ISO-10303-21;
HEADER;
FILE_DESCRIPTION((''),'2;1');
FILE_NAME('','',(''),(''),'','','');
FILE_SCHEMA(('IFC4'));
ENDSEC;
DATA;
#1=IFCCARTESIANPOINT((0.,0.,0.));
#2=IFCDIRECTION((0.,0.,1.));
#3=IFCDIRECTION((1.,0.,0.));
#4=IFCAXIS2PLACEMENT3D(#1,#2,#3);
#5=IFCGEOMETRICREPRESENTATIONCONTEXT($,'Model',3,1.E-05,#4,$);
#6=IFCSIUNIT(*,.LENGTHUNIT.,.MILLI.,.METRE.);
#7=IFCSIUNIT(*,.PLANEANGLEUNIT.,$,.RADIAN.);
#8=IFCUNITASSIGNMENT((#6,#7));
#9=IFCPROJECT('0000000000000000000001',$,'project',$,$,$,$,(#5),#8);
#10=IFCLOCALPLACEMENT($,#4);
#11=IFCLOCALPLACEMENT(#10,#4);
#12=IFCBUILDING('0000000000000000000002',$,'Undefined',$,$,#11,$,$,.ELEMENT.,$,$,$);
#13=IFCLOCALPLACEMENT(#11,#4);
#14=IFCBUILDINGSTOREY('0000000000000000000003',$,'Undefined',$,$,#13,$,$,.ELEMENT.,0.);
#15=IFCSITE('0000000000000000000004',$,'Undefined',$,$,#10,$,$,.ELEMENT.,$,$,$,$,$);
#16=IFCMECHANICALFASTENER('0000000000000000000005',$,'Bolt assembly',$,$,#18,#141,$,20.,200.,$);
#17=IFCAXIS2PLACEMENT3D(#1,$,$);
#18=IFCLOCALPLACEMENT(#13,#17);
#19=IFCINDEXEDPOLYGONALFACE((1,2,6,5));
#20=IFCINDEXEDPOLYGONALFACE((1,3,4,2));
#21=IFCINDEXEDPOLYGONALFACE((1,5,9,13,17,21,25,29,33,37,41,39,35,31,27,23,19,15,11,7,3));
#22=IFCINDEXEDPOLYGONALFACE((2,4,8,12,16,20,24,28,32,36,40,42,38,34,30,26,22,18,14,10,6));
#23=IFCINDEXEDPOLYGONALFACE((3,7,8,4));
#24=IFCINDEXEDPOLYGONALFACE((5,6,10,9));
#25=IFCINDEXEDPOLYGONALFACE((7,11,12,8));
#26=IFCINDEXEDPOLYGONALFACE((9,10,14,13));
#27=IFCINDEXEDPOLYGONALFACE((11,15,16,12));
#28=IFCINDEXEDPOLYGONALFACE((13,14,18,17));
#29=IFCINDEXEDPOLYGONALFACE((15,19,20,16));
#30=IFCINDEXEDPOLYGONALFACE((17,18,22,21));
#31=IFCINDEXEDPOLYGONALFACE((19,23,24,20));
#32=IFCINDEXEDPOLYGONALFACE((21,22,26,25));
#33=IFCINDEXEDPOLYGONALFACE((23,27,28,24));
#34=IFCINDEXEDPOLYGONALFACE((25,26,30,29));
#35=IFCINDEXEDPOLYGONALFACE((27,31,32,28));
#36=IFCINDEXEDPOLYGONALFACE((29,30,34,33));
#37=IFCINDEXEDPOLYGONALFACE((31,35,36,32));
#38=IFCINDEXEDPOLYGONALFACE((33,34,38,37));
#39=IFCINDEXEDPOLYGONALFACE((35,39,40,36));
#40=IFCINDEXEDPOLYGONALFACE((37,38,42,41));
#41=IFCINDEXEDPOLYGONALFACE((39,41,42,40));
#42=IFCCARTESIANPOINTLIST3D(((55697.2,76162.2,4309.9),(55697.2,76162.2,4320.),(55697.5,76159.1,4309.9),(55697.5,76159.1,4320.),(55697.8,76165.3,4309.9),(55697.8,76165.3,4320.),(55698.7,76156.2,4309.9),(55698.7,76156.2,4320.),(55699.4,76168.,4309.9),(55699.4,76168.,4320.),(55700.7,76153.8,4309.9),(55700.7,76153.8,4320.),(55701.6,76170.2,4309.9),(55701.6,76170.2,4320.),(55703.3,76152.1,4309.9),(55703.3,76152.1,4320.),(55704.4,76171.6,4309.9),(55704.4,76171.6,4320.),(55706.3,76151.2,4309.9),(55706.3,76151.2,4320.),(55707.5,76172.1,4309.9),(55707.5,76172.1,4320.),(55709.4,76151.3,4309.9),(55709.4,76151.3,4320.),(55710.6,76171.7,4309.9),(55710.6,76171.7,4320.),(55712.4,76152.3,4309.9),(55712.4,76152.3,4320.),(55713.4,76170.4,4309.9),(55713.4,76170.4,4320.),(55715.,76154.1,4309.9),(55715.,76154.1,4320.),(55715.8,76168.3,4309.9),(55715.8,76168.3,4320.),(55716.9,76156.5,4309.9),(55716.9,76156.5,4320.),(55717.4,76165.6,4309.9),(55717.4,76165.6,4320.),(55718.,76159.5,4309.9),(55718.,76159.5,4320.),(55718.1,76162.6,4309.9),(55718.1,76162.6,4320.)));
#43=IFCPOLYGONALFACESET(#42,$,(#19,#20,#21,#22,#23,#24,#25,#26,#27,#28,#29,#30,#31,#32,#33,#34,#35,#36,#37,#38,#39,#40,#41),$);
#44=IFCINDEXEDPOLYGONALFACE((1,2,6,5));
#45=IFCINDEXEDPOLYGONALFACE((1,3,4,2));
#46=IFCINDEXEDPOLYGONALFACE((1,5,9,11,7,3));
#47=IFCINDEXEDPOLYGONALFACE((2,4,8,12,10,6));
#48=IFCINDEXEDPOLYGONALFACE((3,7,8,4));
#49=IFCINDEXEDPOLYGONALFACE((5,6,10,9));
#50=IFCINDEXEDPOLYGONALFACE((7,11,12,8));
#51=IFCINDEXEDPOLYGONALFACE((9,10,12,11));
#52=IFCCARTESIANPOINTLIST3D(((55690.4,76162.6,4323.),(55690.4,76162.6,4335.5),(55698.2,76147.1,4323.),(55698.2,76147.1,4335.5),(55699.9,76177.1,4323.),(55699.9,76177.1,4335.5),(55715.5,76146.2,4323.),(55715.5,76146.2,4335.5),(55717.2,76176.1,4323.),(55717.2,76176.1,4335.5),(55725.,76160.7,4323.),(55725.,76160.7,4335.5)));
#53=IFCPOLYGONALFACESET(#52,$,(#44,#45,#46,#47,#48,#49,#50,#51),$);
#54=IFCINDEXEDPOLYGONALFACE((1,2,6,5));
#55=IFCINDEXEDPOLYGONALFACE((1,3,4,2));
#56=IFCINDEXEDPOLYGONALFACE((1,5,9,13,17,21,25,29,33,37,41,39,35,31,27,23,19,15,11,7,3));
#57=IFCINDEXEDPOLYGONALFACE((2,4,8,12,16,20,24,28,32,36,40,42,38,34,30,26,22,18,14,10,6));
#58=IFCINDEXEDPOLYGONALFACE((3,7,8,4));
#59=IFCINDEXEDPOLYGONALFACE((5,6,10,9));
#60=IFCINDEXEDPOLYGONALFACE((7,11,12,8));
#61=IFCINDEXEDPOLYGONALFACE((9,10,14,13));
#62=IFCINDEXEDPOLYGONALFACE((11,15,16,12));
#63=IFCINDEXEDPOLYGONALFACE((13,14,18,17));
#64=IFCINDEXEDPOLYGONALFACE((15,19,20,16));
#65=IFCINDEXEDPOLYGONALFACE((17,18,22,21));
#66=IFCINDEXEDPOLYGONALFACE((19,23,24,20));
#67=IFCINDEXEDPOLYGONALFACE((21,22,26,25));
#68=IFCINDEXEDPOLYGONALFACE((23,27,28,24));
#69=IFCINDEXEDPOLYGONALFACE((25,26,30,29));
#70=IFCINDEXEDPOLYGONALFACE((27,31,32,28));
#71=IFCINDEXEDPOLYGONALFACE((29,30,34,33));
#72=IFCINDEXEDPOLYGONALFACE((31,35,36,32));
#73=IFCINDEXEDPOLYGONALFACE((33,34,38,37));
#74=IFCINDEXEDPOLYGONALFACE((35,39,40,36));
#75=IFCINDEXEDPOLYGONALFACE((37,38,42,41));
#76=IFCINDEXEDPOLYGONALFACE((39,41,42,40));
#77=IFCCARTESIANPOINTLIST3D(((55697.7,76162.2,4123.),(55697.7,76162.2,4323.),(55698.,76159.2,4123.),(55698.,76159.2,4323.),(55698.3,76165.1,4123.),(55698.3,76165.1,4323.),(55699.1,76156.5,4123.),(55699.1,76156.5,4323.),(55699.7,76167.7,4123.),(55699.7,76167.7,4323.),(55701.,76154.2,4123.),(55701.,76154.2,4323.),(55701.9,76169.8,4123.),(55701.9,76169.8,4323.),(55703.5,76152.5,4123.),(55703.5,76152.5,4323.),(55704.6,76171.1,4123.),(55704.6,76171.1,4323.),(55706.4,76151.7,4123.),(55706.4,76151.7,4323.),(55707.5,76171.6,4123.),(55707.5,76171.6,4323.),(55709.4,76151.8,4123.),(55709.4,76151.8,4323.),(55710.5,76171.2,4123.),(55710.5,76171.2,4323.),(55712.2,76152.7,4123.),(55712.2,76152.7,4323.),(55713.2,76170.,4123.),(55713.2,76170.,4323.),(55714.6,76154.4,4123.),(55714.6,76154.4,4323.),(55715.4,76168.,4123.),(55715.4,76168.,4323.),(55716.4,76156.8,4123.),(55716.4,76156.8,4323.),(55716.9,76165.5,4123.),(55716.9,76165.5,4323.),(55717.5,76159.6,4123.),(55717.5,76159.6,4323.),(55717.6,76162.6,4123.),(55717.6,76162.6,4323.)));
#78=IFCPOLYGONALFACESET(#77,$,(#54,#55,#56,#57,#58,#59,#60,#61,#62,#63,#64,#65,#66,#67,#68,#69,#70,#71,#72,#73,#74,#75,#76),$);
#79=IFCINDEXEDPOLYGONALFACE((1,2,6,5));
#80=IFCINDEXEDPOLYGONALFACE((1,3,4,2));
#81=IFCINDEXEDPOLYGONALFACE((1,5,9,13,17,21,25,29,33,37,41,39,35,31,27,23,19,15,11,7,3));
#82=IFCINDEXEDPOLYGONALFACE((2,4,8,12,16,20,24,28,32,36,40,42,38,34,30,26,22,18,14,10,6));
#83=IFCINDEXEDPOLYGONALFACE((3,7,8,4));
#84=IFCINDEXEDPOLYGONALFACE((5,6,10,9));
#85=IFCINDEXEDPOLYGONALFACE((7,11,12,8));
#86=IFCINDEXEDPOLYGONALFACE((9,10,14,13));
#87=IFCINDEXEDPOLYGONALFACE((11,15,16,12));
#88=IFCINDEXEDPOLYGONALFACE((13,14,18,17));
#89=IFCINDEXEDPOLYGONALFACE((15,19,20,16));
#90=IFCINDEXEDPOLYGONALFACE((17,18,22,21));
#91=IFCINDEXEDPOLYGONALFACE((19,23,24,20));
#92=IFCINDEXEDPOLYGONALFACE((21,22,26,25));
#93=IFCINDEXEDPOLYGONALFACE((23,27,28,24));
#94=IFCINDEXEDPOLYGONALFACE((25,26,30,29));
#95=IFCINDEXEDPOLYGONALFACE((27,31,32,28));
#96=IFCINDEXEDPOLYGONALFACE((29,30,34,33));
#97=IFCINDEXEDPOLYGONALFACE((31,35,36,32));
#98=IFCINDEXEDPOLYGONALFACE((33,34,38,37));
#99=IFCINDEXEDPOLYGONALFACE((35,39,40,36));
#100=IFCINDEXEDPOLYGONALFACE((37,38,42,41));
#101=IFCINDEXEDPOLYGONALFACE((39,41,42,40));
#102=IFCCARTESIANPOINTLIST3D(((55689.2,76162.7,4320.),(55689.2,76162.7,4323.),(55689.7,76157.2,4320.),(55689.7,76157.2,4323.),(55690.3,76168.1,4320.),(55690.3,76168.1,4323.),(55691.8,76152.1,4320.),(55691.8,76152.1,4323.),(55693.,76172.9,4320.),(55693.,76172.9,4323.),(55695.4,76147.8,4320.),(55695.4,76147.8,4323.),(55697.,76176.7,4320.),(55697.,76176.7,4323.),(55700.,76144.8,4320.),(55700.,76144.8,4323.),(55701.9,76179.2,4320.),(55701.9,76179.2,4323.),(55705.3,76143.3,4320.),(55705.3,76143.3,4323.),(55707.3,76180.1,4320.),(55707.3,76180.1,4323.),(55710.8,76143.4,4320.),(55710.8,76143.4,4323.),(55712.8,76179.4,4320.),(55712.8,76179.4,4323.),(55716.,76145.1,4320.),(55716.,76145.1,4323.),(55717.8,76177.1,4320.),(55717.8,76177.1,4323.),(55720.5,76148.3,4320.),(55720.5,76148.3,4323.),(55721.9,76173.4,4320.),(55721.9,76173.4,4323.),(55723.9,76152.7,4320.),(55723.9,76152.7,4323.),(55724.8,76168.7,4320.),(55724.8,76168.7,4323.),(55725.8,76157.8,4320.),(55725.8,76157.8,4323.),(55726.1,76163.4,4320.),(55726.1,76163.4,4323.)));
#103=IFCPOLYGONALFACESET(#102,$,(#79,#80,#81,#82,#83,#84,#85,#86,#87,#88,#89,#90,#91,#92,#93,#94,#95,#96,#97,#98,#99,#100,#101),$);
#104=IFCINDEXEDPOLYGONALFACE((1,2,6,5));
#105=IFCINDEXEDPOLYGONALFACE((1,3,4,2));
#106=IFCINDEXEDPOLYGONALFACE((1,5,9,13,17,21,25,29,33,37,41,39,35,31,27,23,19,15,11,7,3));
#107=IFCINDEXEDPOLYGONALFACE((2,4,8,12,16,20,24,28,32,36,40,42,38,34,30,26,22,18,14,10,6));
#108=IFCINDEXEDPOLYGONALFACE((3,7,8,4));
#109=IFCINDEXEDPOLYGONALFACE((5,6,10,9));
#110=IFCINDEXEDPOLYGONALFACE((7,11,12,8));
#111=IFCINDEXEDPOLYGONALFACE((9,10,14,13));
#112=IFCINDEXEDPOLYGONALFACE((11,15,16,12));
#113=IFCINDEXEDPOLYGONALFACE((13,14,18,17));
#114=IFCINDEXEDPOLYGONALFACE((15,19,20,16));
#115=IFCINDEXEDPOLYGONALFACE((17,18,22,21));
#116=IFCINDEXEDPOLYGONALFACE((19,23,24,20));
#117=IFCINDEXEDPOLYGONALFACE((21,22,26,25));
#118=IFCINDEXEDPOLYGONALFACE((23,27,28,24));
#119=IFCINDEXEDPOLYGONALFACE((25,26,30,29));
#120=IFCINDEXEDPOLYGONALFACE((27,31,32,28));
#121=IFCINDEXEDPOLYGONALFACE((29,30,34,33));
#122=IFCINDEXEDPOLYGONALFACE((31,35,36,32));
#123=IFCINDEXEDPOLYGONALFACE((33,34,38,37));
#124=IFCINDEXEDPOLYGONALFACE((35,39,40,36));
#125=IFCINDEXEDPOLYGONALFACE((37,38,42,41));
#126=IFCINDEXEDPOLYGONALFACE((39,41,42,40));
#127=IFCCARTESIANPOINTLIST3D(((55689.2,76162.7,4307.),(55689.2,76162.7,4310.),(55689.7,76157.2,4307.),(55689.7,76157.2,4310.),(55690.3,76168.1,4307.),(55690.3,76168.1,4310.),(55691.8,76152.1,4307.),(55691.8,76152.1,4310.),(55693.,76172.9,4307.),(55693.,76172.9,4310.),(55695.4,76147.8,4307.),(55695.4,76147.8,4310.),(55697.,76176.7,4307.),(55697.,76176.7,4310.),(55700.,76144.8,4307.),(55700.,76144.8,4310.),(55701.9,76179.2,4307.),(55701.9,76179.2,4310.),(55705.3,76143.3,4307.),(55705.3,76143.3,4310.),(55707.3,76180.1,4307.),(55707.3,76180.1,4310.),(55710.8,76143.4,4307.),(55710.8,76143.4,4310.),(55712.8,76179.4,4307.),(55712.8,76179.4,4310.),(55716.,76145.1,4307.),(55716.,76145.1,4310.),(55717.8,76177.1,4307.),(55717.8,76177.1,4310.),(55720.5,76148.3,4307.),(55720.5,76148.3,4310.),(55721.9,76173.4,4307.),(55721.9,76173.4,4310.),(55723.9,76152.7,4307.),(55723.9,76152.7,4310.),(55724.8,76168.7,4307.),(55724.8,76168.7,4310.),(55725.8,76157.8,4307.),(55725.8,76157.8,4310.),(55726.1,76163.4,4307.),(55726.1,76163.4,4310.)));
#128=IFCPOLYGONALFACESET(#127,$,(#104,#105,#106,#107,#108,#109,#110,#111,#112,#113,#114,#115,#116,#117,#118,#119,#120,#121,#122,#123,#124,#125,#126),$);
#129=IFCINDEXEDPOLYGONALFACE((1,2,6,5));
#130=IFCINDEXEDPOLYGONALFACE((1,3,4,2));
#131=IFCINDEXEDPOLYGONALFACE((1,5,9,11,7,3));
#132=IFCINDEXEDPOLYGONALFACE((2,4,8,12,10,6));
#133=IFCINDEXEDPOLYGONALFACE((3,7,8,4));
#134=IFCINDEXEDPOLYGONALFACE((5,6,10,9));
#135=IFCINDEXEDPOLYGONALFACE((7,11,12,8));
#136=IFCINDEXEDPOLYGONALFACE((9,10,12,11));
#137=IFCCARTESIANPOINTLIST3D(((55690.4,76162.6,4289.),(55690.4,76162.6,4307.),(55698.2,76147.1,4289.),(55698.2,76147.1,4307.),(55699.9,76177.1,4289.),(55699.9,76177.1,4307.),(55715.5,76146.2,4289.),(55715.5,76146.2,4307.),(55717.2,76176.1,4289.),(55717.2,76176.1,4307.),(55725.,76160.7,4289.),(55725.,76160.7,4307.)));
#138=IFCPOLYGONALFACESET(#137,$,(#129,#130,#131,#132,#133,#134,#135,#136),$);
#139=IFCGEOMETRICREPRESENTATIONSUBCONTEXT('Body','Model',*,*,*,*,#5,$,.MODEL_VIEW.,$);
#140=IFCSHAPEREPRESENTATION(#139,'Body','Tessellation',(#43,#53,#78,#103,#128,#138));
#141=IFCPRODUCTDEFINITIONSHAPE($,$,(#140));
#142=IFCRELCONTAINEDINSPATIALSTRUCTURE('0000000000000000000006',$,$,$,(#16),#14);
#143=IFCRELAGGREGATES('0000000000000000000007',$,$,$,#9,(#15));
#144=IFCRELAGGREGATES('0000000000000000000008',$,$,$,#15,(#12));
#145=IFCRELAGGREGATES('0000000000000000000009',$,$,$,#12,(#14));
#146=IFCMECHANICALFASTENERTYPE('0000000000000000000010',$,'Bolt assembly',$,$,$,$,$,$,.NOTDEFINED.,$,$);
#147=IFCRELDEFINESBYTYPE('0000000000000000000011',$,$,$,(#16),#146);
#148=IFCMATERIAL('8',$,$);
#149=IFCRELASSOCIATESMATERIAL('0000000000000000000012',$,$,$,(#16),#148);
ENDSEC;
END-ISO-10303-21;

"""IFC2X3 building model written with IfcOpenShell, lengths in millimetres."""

from ifc_helpers import new_model, si_unit, frame, origin_with_axes, origin_2d_with_axis, place, context, subcontext, project, spatial, polyline, circle, outline, extrude, source, transform, mapped, material, type_object, element, save


model = new_model("IFC2X3")

# Units and contexts
model_context = context("Model", 3, precision=1e-05, world=origin_with_axes())
body_context = subcontext(model_context, "Body", "Model", "MODEL_VIEW")
ifc_project = project(units=[si_unit("LENGTHUNIT", "METRE", prefix="MILLI"), si_unit("PLANEANGLEUNIT", "RADIAN")], contexts=[model_context])

# Site, building, storey
site_placement = place(None, origin_with_axes())
site = spatial("IfcSite", under=ifc_project, at=site_placement, Name="Undefined", CompositionType="ELEMENT")
building_placement = place(site_placement, origin_with_axes())
building = spatial("IfcBuilding", under=site, at=building_placement, Name="Undefined", CompositionType="ELEMENT")
storey_placement = place(building_placement, origin_with_axes())
storey = spatial("IfcBuildingStorey", under=building, at=storey_placement, Name="Undefined", CompositionType="ELEMENT", Elevation=0.0)

# Mechanical fastener
ifc_material_1 = material(Name="8")
mechanical_fastener_type = type_object("IfcMechanicalFastenerType", Name="Bolt assembly")
shared_shape_1 = source(origin_with_axes(), body_context, "Body", "SweptSolid", [
    extrude(circle(Radius=10.5, at=origin_2d_with_axis()), frame((0.0, 0.0, 0.0), z_axis=(0.0, 1.0, 0.0), x_axis=(1.0, 0.0, 0.0)), (0.0, 0.0, 1.0), 10.1),
    extrude(outline(polyline([(17.3, 0.0), (8.7, 15.0), (-8.7, 15.0), (-17.3, 0.0), (-8.7, -15.0), (8.7, -15.0), (17.3, 0.0)])), frame((0.0, -15.5, 0.0), z_axis=(0.0, 1.0, 0.0), x_axis=(1.0, 0.0, 0.0)), (0.0, 0.0, 1.0), 12.5),
    extrude(circle(Radius=10.0, at=origin_2d_with_axis()), frame((0.0, -3.0, 0.0), z_axis=(0.0, 1.0, 0.0), x_axis=(1.0, 0.0, 0.0)), (0.0, 0.0, 1.0), 200.0),
    extrude(circle(Radius=18.5, at=origin_2d_with_axis()), frame((0.0, -3.0, 0.0), z_axis=(0.0, 1.0, 0.0), x_axis=(1.0, 0.0, 0.0)), (0.0, 0.0, 1.0), 3.0),
    extrude(circle(Radius=18.5, at=origin_2d_with_axis()), frame((0.0, 10.0, 0.0), z_axis=(0.0, 1.0, 0.0), x_axis=(1.0, 0.0, 0.0)), (0.0, 0.0, 1.0), 3.0),
    extrude(outline(polyline([(17.3, 0.0), (8.7, 15.0), (-8.7, 15.0), (-17.3, 0.0), (-8.7, -15.0), (8.7, -15.0), (17.3, 0.0)])), frame((0.0, 13.0, 0.0), z_axis=(0.0, 1.0, 0.0), x_axis=(1.0, 0.0, 0.0)), (0.0, 0.0, 1.0), 18.0),
])
mechanical_fastener_1_placement = place(storey_placement, frame((55707.7, 76161.6, 4320.0), z_axis=(0.892799, 0.450455, 0.0), x_axis=(0.450455, -0.892799, 0.0)))
element("IfcMechanicalFastener", 1, at=mechanical_fastener_1_placement, inside=storey, type_object=mechanical_fastener_type, material=ifc_material_1, Name="Bolt assembly", NominalDiameter=20.0, NominalLength=200.0, context=body_context, shape_type="MappedRepresentation", body=[
    mapped(shared_shape_1, transform((0.0, 0.0, 0.0))),
])

save(model, "model.ifc")
